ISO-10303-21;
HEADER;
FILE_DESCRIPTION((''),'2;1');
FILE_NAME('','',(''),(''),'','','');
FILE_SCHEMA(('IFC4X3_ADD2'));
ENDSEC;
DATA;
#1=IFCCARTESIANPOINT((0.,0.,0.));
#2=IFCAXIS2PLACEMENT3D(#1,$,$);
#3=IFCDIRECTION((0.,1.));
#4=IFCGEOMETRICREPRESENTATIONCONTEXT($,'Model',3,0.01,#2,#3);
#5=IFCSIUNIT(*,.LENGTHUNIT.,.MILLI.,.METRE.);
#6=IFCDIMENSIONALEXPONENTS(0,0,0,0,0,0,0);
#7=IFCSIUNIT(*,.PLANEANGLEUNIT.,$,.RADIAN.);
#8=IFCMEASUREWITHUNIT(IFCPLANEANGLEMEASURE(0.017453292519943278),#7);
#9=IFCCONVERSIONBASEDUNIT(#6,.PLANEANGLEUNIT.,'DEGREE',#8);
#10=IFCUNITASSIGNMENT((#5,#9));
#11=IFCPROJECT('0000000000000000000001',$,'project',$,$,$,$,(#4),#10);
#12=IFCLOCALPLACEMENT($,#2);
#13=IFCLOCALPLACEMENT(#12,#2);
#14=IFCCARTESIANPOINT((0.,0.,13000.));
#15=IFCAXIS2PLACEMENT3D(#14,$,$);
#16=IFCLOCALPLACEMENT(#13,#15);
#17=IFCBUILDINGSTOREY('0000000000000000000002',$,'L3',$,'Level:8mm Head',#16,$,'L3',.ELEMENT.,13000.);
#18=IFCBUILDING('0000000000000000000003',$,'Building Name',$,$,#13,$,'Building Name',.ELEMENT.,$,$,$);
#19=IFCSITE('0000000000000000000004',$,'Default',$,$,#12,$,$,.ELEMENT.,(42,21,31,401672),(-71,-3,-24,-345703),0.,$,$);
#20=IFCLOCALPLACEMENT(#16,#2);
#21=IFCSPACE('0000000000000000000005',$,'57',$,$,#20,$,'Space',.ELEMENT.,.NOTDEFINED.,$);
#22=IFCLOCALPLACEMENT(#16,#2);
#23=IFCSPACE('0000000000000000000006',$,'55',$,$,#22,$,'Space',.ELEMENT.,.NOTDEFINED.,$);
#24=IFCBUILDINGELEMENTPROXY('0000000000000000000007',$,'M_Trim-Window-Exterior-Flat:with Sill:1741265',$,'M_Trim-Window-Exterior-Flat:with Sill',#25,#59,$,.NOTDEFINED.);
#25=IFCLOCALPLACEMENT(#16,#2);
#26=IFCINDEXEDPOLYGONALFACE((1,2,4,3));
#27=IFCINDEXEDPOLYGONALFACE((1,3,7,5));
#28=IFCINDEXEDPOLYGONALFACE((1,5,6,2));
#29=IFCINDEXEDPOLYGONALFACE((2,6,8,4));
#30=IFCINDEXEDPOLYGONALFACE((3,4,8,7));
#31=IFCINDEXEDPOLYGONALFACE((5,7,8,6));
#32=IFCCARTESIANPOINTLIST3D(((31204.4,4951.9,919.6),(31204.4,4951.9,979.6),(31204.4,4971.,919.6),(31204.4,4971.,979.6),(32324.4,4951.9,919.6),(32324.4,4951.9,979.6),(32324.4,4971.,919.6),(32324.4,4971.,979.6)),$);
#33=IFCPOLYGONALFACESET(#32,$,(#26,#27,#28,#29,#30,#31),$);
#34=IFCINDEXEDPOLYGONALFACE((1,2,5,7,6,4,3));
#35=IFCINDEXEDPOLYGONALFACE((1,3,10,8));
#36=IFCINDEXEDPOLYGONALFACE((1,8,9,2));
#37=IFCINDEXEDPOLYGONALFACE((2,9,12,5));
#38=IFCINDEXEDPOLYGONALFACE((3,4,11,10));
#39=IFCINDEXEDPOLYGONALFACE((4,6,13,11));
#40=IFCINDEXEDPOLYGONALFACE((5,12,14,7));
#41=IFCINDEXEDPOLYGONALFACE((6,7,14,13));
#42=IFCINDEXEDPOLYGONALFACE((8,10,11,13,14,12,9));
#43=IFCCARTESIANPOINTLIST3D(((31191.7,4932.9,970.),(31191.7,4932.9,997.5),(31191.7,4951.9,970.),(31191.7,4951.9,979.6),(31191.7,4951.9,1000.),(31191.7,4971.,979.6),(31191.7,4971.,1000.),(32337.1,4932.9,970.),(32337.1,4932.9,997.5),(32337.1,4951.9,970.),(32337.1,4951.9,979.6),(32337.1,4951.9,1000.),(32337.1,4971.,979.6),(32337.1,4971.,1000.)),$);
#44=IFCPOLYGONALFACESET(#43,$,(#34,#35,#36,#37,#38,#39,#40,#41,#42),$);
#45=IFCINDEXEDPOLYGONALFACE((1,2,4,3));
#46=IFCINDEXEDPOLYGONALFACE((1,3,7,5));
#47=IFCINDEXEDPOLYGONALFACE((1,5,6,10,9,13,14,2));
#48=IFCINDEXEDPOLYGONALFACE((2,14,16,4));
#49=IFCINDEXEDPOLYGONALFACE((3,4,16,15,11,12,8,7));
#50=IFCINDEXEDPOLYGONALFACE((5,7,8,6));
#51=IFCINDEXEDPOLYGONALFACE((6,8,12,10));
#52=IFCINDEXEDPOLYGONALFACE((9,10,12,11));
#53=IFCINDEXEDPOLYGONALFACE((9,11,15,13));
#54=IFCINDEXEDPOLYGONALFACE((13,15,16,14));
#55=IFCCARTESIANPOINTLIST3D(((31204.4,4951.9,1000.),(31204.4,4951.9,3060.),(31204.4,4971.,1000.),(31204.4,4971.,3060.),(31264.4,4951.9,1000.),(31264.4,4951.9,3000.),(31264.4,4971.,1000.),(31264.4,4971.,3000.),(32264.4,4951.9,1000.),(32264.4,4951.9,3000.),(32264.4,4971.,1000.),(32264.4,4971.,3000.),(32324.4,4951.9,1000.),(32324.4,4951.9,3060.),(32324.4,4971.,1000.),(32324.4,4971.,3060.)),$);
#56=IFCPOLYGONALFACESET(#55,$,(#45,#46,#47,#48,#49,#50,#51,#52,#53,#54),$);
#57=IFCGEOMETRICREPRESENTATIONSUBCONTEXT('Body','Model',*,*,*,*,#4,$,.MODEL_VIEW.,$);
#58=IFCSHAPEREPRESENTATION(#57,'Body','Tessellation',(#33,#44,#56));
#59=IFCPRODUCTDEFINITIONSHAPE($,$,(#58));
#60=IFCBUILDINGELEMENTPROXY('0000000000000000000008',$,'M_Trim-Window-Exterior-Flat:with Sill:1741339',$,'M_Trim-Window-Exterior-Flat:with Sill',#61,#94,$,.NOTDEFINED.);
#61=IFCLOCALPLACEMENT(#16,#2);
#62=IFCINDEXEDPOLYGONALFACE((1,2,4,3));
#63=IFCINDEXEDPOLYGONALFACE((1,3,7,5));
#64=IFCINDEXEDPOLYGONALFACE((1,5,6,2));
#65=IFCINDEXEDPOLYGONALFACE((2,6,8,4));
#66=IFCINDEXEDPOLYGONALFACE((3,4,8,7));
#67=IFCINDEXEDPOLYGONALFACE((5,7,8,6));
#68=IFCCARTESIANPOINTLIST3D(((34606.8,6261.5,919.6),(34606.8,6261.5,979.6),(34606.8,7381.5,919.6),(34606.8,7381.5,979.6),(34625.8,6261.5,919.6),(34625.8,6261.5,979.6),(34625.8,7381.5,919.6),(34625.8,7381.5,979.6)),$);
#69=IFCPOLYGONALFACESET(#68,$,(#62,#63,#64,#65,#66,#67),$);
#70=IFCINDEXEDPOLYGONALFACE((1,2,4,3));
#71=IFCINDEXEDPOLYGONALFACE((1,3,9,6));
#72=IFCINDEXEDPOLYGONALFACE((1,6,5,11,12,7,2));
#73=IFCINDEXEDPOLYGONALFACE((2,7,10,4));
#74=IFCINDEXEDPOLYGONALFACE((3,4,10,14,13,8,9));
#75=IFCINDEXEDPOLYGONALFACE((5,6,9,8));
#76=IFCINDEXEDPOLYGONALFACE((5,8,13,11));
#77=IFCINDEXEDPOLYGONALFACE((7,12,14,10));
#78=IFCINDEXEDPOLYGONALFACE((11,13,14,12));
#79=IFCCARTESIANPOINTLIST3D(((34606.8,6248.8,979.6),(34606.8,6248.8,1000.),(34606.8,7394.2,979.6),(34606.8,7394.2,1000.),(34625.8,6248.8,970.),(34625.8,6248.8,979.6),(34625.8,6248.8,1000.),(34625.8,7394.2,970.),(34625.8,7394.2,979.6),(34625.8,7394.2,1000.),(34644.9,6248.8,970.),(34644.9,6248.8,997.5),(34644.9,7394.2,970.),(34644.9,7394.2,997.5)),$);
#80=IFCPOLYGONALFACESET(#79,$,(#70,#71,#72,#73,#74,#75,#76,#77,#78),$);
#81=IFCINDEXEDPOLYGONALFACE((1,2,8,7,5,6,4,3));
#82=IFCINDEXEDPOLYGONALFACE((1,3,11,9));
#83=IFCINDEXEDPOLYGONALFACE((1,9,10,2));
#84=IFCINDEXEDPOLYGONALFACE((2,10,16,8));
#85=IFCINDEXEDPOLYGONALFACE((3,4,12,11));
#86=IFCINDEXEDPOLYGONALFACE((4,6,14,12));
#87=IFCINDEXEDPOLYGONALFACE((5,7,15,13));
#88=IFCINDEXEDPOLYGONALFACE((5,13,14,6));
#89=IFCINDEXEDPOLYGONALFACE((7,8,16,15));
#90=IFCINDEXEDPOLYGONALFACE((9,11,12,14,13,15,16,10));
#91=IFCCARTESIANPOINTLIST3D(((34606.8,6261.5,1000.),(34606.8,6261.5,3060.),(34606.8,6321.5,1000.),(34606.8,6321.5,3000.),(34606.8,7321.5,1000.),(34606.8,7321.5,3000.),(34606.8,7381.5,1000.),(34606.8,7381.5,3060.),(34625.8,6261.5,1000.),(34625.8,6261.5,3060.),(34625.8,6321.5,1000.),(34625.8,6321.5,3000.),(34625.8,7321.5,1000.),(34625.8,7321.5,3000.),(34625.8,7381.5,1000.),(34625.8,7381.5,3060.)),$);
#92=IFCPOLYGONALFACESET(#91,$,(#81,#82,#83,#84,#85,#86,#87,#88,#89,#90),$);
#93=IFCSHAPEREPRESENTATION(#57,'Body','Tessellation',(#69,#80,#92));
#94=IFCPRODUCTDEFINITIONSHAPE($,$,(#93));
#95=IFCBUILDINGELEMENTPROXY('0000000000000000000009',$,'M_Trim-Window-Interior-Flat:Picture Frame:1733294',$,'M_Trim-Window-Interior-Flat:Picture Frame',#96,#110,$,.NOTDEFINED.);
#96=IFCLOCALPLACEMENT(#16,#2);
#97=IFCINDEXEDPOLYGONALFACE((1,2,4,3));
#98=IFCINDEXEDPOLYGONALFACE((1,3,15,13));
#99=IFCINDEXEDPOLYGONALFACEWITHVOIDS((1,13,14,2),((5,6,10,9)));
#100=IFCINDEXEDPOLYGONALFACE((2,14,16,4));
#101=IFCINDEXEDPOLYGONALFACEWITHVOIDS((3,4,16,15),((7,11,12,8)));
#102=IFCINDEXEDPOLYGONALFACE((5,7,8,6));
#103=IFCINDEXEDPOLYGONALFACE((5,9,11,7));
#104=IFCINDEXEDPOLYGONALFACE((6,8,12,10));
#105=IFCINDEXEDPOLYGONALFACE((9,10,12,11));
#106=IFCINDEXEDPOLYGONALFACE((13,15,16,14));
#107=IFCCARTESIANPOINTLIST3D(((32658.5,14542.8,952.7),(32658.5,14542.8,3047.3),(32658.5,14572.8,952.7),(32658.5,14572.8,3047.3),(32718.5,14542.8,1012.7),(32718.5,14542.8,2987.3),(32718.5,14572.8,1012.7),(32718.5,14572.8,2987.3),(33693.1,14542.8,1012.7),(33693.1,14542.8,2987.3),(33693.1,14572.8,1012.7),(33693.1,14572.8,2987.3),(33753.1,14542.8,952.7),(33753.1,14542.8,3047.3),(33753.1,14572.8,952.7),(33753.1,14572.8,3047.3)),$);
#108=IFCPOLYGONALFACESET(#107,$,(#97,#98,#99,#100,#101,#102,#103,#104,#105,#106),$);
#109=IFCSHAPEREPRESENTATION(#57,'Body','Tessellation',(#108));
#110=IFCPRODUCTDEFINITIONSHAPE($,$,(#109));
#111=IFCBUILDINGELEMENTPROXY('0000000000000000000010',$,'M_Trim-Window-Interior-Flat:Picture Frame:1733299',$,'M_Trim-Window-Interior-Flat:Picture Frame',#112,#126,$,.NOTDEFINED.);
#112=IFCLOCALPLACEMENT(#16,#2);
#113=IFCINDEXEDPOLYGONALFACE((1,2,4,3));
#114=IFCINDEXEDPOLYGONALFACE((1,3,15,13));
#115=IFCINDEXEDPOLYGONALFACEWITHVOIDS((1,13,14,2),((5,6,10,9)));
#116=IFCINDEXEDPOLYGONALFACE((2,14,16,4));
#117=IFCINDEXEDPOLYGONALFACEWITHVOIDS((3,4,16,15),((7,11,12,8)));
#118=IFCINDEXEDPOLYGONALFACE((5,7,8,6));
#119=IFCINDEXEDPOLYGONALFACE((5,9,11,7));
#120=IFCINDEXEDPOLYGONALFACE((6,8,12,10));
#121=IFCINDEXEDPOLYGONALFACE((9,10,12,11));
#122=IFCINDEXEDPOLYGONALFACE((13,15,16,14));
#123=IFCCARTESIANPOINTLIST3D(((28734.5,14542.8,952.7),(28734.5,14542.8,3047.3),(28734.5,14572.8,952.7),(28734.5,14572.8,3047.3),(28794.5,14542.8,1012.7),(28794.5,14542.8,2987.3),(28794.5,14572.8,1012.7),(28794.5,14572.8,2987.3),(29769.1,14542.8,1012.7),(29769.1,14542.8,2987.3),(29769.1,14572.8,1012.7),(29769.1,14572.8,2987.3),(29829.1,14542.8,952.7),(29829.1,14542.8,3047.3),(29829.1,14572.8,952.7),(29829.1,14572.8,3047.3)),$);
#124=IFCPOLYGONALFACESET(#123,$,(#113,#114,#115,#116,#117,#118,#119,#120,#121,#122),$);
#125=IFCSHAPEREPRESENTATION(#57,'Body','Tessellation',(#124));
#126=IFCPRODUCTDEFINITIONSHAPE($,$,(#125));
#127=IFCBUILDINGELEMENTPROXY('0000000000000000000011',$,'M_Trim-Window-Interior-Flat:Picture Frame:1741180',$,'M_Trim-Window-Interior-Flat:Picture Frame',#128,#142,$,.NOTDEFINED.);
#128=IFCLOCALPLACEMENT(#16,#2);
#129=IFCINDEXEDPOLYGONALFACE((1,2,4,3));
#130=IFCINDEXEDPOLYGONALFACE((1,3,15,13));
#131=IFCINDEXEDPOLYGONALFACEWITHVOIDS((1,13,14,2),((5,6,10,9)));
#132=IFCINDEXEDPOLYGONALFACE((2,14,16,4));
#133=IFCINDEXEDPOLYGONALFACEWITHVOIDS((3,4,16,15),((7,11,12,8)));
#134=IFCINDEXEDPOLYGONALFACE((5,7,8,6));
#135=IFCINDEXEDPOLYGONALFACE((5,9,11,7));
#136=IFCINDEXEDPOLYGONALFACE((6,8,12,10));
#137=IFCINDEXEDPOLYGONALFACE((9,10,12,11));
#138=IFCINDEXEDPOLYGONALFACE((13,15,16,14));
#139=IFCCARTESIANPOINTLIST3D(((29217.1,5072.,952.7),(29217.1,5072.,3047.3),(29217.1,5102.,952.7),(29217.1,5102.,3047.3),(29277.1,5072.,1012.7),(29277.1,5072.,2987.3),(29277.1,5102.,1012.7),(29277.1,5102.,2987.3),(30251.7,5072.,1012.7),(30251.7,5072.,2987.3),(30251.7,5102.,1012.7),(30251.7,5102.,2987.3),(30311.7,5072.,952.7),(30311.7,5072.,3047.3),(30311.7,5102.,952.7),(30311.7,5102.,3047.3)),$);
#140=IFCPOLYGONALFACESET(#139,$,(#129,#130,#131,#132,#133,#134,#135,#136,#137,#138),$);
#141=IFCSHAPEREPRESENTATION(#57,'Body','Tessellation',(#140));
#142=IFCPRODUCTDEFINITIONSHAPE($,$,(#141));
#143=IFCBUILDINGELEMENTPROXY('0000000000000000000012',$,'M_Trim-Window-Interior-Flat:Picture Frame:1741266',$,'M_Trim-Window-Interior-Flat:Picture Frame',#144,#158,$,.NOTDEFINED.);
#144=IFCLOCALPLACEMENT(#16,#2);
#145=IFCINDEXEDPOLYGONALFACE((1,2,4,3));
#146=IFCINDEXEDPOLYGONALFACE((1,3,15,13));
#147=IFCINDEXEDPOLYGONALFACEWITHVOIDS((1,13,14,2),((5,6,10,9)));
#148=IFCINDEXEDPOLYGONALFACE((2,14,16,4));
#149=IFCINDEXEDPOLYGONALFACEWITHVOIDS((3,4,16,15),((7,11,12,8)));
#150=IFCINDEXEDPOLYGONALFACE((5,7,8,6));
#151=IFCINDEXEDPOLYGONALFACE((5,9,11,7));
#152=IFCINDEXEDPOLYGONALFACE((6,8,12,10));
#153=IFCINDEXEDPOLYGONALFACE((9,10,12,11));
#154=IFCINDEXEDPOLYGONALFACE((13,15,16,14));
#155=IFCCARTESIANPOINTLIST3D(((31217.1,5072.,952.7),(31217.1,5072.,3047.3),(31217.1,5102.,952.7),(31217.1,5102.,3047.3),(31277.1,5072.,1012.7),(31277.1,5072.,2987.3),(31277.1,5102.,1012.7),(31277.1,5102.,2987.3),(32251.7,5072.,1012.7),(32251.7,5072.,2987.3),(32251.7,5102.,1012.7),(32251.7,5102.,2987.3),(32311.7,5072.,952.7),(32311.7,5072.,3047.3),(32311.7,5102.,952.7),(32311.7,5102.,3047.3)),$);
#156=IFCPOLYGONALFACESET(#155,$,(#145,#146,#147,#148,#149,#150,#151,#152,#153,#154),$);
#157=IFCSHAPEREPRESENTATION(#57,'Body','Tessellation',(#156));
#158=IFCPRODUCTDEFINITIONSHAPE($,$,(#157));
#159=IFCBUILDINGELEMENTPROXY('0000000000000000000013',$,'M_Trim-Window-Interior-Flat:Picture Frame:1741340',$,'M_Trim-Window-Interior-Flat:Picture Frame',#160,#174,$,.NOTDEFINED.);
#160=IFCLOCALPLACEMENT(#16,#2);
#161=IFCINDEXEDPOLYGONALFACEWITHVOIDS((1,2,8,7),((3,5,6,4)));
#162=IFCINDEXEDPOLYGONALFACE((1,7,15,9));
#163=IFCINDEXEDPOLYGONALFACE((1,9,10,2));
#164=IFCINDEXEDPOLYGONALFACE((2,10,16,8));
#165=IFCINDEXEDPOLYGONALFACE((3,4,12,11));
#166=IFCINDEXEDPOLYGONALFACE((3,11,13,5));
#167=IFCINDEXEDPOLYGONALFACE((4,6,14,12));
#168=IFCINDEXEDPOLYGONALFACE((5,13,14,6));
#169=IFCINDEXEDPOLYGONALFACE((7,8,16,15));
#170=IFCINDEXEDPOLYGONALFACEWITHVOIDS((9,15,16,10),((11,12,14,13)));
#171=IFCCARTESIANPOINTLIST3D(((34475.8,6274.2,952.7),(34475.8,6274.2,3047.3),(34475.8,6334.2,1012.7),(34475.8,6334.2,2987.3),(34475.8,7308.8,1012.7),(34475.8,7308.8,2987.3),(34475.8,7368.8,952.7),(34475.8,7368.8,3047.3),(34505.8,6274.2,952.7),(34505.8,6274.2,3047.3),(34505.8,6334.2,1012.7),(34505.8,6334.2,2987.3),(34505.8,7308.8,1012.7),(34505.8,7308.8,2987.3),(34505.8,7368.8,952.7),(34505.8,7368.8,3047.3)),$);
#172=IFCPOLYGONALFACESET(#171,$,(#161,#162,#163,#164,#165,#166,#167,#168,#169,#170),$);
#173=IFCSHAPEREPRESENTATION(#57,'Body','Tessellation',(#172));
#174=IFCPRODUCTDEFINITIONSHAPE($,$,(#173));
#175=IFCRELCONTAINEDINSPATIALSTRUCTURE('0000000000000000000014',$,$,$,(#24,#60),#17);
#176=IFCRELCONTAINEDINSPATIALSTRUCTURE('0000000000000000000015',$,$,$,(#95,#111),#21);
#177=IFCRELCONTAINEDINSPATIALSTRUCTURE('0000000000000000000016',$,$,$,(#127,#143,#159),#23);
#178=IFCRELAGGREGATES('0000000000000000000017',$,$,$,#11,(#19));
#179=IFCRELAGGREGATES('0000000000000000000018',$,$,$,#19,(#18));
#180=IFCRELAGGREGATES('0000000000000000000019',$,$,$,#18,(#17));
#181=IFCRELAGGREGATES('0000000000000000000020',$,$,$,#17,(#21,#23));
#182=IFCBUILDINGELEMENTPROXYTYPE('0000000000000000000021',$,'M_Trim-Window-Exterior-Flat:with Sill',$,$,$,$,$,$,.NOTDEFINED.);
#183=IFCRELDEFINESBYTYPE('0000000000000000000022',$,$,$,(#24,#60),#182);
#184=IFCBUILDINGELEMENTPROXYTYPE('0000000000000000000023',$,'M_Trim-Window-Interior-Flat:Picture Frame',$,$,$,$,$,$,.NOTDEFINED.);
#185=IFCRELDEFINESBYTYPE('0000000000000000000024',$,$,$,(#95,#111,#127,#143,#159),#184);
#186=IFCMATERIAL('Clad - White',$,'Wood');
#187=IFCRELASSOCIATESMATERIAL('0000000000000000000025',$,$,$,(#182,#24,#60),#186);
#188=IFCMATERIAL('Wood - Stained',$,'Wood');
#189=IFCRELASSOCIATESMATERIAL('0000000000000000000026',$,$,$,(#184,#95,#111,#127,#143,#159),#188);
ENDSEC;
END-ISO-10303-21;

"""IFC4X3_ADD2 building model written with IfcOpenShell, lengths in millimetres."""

from ifc_helpers import new_model, entity, si_unit, converted_unit, direction, frame, frame_2d, origin, place, context, subcontext, project, spatial, polyline, rectangle, outline, extrude, source, transform, mapped, material, type_object, type_shapes, element, save


model = new_model("IFC4X3_ADD2")

# Units and contexts
model_context = context("Model", 3, precision=0.01, world=origin(), true_north=direction((0.0, 1.0)))
body_context = subcontext(model_context, "Body", "Model", "MODEL_VIEW")
ifc_project = project(units=[si_unit("LENGTHUNIT", "METRE", prefix="MILLI"), converted_unit("PLANEANGLEUNIT", "DEGREE", entity("IfcPlaneAngleMeasure", 0.017453292519943278), si_unit("PLANEANGLEUNIT", "RADIAN"), dimensions=[0, 0, 0, 0, 0, 0, 0])], contexts=[model_context])

# Site, building, storey
site_placement = place(None, origin())
site = spatial("IfcSite", under=ifc_project, at=site_placement, Name="Default", CompositionType="ELEMENT", RefLatitude=(42, 21, 31, 401672), RefLongitude=(-71, -3, -24, -345703), RefElevation=0.0)
building_placement = place(site_placement, origin())
building = spatial("IfcBuilding", under=site, at=building_placement, Name="Building Name", LongName="Building Name", CompositionType="ELEMENT")
storey_placement = place(building_placement, frame((0.0, 0.0, 13000.0)))
storey = spatial("IfcBuildingStorey", under=building, at=storey_placement, Name="L3", ObjectType="Level:8mm Head", LongName="L3", CompositionType="ELEMENT", Elevation=13000.0)

# Building element proxies
ifc_material_1 = material(Name="Clad - White", Category="Wood")
ifc_material_2 = material(Name="Wood - Stained", Category="Wood")
building_element_proxy_type_1 = type_object("IfcBuildingElementProxyType", Name="M_Trim-Window-Exterior-Flat:with Sill", PredefinedType="NOTDEFINED", material=ifc_material_1)
shared_shape_1 = source(origin(), body_context, "Body", "SweptSolid", [
    extrude(rectangle(XDim=1120.0, YDim=60.0, at=frame_2d((0.0, 0.0), x_axis=(1.0, 0.0))), frame((0.0, -2050.4, 0.0), z_axis=(0.0, 0.0, 1.0), x_axis=(-1.0, 0.0, 0.0)), (0.0, 0.0, 1.0), 19.0),
    extrude(outline(polyline([(-19.0, -15.2), (0.0, -15.2), (0.0, -5.7), (19.0, -5.7), (19.0, 14.8), (0.0, 14.8), (-19.0, 12.3), (-19.0, -15.2)])), frame((-572.7, -2014.8, 19.0), z_axis=(1.0, 0.0, 0.0), x_axis=(0.0, 0.0, -1.0)), (0.0, 0.0, 1.0), 1145.4),
    extrude(outline(polyline([(-1045.0, -560.0), (1015.0, -560.0), (1015.0, -500.0), (-985.0, -500.0), (-985.0, 500.0), (1015.0, 500.0), (1015.0, 560.0), (-1045.0, 560.0), (-1045.0, -560.0)])), frame((0.0, -985.0, 0.0), z_axis=(0.0, 0.0, 1.0), x_axis=(0.0, -1.0, 0.0)), (0.0, 0.0, 1.0), 19.0),
])
type_shapes(building_element_proxy_type_1, [shared_shape_1])
for number, where, z_axis, x_axis, name in (
    (1, (31764.4, 4971.0, 3000.0), (0.0, -1.0, 0.0), (1.0, 0.0, 0.0), "M_Trim-Window-Exterior-Flat:with Sill:1741265"),
    (2, (34606.8, 6821.5, 3000.0), (1.0, 0.0, 0.0), (0.0, 1.0, 0.0), "M_Trim-Window-Exterior-Flat:with Sill:1741339"),
):
    element("IfcBuildingElementProxy", number, at=place(storey_placement, frame(where, z_axis=z_axis, x_axis=x_axis)), inside=storey, type_object=building_element_proxy_type_1, material=ifc_material_1, Name=name, ObjectType="M_Trim-Window-Exterior-Flat:with Sill", PredefinedType="NOTDEFINED", context=body_context, shape_type="MappedRepresentation", body=[
        mapped(shared_shape_1, transform((0.0, 0.0, 0.0), scale=1.0)),
    ])

# Shared definitions
space_1_placement = place(storey_placement, origin())
space_1 = spatial("IfcSpace", under=storey, at=space_1_placement, Name="57", LongName="Space", CompositionType="ELEMENT", PredefinedType="NOTDEFINED")

# Building element proxies
building_element_proxy_type_2 = type_object("IfcBuildingElementProxyType", Name="M_Trim-Window-Interior-Flat:Picture Frame", PredefinedType="NOTDEFINED", material=ifc_material_2)
shared_shape_2 = source(origin(), body_context, "Body", "SweptSolid", [
    extrude(outline(polyline([(-547.3, -1047.3), (547.3, -1047.3), (547.3, 1047.3), (-547.3, 1047.3), (-547.3, -1047.3)]), holes=[polyline([(-487.3, -987.3), (-487.3, 987.3), (487.3, 987.3), (487.3, -987.3), (-487.3, -987.3)])]), frame((0.0, -1000.0, 0.0), z_axis=(0.0, 0.0, 1.0), x_axis=(-1.0, 0.0, 0.0)), (0.0, 0.0, 1.0), 30.0),
])
type_shapes(building_element_proxy_type_2, [shared_shape_2])
for number, where, z_axis, x_axis, name in (
    (3, (33205.8, 14572.8, 3000.0), (0.0, -1.0, 0.0), (1.0, 0.0, 0.0), "M_Trim-Window-Interior-Flat:Picture Frame:1733294"),
    (4, (29281.8, 14572.8, 3000.0), (0.0, -1.0, 0.0), (1.0, 0.0, 0.0), "M_Trim-Window-Interior-Flat:Picture Frame:1733299"),
):
    element("IfcBuildingElementProxy", number, at=place(space_1_placement, frame(where, z_axis=z_axis, x_axis=x_axis)), inside=space_1, type_object=building_element_proxy_type_2, material=ifc_material_2, Name=name, ObjectType="M_Trim-Window-Interior-Flat:Picture Frame", PredefinedType="NOTDEFINED", context=body_context, shape_type="MappedRepresentation", body=[
        mapped(shared_shape_2, transform((0.0, 0.0, 0.0), scale=1.0)),
    ])

# Shared definitions
space_2_placement = place(storey_placement, origin())
space_2 = spatial("IfcSpace", under=storey, at=space_2_placement, Name="55", LongName="Space", CompositionType="ELEMENT", PredefinedType="NOTDEFINED")

# Building element proxies
for number, where, z_axis, x_axis, name in (
    (5, (29764.4, 5072.0, 3000.0), (0.0, 1.0, 0.0), (-1.0, 0.0, 0.0), "M_Trim-Window-Interior-Flat:Picture Frame:1741180"),
    (6, (31764.4, 5072.0, 3000.0), (0.0, 1.0, 0.0), (-1.0, 0.0, 0.0), "M_Trim-Window-Interior-Flat:Picture Frame:1741266"),
    (7, (34505.8, 6821.5, 3000.0), (-1.0, 0.0, 0.0), (0.0, -1.0, 0.0), "M_Trim-Window-Interior-Flat:Picture Frame:1741340"),
):
    element("IfcBuildingElementProxy", number, at=place(space_2_placement, frame(where, z_axis=z_axis, x_axis=x_axis)), inside=space_2, type_object=building_element_proxy_type_2, material=ifc_material_2, Name=name, ObjectType="M_Trim-Window-Interior-Flat:Picture Frame", PredefinedType="NOTDEFINED", context=body_context, shape_type="MappedRepresentation", body=[
        mapped(shared_shape_2, transform((0.0, 0.0, 0.0), scale=1.0)),
    ])

save(model, "model.ifc")
